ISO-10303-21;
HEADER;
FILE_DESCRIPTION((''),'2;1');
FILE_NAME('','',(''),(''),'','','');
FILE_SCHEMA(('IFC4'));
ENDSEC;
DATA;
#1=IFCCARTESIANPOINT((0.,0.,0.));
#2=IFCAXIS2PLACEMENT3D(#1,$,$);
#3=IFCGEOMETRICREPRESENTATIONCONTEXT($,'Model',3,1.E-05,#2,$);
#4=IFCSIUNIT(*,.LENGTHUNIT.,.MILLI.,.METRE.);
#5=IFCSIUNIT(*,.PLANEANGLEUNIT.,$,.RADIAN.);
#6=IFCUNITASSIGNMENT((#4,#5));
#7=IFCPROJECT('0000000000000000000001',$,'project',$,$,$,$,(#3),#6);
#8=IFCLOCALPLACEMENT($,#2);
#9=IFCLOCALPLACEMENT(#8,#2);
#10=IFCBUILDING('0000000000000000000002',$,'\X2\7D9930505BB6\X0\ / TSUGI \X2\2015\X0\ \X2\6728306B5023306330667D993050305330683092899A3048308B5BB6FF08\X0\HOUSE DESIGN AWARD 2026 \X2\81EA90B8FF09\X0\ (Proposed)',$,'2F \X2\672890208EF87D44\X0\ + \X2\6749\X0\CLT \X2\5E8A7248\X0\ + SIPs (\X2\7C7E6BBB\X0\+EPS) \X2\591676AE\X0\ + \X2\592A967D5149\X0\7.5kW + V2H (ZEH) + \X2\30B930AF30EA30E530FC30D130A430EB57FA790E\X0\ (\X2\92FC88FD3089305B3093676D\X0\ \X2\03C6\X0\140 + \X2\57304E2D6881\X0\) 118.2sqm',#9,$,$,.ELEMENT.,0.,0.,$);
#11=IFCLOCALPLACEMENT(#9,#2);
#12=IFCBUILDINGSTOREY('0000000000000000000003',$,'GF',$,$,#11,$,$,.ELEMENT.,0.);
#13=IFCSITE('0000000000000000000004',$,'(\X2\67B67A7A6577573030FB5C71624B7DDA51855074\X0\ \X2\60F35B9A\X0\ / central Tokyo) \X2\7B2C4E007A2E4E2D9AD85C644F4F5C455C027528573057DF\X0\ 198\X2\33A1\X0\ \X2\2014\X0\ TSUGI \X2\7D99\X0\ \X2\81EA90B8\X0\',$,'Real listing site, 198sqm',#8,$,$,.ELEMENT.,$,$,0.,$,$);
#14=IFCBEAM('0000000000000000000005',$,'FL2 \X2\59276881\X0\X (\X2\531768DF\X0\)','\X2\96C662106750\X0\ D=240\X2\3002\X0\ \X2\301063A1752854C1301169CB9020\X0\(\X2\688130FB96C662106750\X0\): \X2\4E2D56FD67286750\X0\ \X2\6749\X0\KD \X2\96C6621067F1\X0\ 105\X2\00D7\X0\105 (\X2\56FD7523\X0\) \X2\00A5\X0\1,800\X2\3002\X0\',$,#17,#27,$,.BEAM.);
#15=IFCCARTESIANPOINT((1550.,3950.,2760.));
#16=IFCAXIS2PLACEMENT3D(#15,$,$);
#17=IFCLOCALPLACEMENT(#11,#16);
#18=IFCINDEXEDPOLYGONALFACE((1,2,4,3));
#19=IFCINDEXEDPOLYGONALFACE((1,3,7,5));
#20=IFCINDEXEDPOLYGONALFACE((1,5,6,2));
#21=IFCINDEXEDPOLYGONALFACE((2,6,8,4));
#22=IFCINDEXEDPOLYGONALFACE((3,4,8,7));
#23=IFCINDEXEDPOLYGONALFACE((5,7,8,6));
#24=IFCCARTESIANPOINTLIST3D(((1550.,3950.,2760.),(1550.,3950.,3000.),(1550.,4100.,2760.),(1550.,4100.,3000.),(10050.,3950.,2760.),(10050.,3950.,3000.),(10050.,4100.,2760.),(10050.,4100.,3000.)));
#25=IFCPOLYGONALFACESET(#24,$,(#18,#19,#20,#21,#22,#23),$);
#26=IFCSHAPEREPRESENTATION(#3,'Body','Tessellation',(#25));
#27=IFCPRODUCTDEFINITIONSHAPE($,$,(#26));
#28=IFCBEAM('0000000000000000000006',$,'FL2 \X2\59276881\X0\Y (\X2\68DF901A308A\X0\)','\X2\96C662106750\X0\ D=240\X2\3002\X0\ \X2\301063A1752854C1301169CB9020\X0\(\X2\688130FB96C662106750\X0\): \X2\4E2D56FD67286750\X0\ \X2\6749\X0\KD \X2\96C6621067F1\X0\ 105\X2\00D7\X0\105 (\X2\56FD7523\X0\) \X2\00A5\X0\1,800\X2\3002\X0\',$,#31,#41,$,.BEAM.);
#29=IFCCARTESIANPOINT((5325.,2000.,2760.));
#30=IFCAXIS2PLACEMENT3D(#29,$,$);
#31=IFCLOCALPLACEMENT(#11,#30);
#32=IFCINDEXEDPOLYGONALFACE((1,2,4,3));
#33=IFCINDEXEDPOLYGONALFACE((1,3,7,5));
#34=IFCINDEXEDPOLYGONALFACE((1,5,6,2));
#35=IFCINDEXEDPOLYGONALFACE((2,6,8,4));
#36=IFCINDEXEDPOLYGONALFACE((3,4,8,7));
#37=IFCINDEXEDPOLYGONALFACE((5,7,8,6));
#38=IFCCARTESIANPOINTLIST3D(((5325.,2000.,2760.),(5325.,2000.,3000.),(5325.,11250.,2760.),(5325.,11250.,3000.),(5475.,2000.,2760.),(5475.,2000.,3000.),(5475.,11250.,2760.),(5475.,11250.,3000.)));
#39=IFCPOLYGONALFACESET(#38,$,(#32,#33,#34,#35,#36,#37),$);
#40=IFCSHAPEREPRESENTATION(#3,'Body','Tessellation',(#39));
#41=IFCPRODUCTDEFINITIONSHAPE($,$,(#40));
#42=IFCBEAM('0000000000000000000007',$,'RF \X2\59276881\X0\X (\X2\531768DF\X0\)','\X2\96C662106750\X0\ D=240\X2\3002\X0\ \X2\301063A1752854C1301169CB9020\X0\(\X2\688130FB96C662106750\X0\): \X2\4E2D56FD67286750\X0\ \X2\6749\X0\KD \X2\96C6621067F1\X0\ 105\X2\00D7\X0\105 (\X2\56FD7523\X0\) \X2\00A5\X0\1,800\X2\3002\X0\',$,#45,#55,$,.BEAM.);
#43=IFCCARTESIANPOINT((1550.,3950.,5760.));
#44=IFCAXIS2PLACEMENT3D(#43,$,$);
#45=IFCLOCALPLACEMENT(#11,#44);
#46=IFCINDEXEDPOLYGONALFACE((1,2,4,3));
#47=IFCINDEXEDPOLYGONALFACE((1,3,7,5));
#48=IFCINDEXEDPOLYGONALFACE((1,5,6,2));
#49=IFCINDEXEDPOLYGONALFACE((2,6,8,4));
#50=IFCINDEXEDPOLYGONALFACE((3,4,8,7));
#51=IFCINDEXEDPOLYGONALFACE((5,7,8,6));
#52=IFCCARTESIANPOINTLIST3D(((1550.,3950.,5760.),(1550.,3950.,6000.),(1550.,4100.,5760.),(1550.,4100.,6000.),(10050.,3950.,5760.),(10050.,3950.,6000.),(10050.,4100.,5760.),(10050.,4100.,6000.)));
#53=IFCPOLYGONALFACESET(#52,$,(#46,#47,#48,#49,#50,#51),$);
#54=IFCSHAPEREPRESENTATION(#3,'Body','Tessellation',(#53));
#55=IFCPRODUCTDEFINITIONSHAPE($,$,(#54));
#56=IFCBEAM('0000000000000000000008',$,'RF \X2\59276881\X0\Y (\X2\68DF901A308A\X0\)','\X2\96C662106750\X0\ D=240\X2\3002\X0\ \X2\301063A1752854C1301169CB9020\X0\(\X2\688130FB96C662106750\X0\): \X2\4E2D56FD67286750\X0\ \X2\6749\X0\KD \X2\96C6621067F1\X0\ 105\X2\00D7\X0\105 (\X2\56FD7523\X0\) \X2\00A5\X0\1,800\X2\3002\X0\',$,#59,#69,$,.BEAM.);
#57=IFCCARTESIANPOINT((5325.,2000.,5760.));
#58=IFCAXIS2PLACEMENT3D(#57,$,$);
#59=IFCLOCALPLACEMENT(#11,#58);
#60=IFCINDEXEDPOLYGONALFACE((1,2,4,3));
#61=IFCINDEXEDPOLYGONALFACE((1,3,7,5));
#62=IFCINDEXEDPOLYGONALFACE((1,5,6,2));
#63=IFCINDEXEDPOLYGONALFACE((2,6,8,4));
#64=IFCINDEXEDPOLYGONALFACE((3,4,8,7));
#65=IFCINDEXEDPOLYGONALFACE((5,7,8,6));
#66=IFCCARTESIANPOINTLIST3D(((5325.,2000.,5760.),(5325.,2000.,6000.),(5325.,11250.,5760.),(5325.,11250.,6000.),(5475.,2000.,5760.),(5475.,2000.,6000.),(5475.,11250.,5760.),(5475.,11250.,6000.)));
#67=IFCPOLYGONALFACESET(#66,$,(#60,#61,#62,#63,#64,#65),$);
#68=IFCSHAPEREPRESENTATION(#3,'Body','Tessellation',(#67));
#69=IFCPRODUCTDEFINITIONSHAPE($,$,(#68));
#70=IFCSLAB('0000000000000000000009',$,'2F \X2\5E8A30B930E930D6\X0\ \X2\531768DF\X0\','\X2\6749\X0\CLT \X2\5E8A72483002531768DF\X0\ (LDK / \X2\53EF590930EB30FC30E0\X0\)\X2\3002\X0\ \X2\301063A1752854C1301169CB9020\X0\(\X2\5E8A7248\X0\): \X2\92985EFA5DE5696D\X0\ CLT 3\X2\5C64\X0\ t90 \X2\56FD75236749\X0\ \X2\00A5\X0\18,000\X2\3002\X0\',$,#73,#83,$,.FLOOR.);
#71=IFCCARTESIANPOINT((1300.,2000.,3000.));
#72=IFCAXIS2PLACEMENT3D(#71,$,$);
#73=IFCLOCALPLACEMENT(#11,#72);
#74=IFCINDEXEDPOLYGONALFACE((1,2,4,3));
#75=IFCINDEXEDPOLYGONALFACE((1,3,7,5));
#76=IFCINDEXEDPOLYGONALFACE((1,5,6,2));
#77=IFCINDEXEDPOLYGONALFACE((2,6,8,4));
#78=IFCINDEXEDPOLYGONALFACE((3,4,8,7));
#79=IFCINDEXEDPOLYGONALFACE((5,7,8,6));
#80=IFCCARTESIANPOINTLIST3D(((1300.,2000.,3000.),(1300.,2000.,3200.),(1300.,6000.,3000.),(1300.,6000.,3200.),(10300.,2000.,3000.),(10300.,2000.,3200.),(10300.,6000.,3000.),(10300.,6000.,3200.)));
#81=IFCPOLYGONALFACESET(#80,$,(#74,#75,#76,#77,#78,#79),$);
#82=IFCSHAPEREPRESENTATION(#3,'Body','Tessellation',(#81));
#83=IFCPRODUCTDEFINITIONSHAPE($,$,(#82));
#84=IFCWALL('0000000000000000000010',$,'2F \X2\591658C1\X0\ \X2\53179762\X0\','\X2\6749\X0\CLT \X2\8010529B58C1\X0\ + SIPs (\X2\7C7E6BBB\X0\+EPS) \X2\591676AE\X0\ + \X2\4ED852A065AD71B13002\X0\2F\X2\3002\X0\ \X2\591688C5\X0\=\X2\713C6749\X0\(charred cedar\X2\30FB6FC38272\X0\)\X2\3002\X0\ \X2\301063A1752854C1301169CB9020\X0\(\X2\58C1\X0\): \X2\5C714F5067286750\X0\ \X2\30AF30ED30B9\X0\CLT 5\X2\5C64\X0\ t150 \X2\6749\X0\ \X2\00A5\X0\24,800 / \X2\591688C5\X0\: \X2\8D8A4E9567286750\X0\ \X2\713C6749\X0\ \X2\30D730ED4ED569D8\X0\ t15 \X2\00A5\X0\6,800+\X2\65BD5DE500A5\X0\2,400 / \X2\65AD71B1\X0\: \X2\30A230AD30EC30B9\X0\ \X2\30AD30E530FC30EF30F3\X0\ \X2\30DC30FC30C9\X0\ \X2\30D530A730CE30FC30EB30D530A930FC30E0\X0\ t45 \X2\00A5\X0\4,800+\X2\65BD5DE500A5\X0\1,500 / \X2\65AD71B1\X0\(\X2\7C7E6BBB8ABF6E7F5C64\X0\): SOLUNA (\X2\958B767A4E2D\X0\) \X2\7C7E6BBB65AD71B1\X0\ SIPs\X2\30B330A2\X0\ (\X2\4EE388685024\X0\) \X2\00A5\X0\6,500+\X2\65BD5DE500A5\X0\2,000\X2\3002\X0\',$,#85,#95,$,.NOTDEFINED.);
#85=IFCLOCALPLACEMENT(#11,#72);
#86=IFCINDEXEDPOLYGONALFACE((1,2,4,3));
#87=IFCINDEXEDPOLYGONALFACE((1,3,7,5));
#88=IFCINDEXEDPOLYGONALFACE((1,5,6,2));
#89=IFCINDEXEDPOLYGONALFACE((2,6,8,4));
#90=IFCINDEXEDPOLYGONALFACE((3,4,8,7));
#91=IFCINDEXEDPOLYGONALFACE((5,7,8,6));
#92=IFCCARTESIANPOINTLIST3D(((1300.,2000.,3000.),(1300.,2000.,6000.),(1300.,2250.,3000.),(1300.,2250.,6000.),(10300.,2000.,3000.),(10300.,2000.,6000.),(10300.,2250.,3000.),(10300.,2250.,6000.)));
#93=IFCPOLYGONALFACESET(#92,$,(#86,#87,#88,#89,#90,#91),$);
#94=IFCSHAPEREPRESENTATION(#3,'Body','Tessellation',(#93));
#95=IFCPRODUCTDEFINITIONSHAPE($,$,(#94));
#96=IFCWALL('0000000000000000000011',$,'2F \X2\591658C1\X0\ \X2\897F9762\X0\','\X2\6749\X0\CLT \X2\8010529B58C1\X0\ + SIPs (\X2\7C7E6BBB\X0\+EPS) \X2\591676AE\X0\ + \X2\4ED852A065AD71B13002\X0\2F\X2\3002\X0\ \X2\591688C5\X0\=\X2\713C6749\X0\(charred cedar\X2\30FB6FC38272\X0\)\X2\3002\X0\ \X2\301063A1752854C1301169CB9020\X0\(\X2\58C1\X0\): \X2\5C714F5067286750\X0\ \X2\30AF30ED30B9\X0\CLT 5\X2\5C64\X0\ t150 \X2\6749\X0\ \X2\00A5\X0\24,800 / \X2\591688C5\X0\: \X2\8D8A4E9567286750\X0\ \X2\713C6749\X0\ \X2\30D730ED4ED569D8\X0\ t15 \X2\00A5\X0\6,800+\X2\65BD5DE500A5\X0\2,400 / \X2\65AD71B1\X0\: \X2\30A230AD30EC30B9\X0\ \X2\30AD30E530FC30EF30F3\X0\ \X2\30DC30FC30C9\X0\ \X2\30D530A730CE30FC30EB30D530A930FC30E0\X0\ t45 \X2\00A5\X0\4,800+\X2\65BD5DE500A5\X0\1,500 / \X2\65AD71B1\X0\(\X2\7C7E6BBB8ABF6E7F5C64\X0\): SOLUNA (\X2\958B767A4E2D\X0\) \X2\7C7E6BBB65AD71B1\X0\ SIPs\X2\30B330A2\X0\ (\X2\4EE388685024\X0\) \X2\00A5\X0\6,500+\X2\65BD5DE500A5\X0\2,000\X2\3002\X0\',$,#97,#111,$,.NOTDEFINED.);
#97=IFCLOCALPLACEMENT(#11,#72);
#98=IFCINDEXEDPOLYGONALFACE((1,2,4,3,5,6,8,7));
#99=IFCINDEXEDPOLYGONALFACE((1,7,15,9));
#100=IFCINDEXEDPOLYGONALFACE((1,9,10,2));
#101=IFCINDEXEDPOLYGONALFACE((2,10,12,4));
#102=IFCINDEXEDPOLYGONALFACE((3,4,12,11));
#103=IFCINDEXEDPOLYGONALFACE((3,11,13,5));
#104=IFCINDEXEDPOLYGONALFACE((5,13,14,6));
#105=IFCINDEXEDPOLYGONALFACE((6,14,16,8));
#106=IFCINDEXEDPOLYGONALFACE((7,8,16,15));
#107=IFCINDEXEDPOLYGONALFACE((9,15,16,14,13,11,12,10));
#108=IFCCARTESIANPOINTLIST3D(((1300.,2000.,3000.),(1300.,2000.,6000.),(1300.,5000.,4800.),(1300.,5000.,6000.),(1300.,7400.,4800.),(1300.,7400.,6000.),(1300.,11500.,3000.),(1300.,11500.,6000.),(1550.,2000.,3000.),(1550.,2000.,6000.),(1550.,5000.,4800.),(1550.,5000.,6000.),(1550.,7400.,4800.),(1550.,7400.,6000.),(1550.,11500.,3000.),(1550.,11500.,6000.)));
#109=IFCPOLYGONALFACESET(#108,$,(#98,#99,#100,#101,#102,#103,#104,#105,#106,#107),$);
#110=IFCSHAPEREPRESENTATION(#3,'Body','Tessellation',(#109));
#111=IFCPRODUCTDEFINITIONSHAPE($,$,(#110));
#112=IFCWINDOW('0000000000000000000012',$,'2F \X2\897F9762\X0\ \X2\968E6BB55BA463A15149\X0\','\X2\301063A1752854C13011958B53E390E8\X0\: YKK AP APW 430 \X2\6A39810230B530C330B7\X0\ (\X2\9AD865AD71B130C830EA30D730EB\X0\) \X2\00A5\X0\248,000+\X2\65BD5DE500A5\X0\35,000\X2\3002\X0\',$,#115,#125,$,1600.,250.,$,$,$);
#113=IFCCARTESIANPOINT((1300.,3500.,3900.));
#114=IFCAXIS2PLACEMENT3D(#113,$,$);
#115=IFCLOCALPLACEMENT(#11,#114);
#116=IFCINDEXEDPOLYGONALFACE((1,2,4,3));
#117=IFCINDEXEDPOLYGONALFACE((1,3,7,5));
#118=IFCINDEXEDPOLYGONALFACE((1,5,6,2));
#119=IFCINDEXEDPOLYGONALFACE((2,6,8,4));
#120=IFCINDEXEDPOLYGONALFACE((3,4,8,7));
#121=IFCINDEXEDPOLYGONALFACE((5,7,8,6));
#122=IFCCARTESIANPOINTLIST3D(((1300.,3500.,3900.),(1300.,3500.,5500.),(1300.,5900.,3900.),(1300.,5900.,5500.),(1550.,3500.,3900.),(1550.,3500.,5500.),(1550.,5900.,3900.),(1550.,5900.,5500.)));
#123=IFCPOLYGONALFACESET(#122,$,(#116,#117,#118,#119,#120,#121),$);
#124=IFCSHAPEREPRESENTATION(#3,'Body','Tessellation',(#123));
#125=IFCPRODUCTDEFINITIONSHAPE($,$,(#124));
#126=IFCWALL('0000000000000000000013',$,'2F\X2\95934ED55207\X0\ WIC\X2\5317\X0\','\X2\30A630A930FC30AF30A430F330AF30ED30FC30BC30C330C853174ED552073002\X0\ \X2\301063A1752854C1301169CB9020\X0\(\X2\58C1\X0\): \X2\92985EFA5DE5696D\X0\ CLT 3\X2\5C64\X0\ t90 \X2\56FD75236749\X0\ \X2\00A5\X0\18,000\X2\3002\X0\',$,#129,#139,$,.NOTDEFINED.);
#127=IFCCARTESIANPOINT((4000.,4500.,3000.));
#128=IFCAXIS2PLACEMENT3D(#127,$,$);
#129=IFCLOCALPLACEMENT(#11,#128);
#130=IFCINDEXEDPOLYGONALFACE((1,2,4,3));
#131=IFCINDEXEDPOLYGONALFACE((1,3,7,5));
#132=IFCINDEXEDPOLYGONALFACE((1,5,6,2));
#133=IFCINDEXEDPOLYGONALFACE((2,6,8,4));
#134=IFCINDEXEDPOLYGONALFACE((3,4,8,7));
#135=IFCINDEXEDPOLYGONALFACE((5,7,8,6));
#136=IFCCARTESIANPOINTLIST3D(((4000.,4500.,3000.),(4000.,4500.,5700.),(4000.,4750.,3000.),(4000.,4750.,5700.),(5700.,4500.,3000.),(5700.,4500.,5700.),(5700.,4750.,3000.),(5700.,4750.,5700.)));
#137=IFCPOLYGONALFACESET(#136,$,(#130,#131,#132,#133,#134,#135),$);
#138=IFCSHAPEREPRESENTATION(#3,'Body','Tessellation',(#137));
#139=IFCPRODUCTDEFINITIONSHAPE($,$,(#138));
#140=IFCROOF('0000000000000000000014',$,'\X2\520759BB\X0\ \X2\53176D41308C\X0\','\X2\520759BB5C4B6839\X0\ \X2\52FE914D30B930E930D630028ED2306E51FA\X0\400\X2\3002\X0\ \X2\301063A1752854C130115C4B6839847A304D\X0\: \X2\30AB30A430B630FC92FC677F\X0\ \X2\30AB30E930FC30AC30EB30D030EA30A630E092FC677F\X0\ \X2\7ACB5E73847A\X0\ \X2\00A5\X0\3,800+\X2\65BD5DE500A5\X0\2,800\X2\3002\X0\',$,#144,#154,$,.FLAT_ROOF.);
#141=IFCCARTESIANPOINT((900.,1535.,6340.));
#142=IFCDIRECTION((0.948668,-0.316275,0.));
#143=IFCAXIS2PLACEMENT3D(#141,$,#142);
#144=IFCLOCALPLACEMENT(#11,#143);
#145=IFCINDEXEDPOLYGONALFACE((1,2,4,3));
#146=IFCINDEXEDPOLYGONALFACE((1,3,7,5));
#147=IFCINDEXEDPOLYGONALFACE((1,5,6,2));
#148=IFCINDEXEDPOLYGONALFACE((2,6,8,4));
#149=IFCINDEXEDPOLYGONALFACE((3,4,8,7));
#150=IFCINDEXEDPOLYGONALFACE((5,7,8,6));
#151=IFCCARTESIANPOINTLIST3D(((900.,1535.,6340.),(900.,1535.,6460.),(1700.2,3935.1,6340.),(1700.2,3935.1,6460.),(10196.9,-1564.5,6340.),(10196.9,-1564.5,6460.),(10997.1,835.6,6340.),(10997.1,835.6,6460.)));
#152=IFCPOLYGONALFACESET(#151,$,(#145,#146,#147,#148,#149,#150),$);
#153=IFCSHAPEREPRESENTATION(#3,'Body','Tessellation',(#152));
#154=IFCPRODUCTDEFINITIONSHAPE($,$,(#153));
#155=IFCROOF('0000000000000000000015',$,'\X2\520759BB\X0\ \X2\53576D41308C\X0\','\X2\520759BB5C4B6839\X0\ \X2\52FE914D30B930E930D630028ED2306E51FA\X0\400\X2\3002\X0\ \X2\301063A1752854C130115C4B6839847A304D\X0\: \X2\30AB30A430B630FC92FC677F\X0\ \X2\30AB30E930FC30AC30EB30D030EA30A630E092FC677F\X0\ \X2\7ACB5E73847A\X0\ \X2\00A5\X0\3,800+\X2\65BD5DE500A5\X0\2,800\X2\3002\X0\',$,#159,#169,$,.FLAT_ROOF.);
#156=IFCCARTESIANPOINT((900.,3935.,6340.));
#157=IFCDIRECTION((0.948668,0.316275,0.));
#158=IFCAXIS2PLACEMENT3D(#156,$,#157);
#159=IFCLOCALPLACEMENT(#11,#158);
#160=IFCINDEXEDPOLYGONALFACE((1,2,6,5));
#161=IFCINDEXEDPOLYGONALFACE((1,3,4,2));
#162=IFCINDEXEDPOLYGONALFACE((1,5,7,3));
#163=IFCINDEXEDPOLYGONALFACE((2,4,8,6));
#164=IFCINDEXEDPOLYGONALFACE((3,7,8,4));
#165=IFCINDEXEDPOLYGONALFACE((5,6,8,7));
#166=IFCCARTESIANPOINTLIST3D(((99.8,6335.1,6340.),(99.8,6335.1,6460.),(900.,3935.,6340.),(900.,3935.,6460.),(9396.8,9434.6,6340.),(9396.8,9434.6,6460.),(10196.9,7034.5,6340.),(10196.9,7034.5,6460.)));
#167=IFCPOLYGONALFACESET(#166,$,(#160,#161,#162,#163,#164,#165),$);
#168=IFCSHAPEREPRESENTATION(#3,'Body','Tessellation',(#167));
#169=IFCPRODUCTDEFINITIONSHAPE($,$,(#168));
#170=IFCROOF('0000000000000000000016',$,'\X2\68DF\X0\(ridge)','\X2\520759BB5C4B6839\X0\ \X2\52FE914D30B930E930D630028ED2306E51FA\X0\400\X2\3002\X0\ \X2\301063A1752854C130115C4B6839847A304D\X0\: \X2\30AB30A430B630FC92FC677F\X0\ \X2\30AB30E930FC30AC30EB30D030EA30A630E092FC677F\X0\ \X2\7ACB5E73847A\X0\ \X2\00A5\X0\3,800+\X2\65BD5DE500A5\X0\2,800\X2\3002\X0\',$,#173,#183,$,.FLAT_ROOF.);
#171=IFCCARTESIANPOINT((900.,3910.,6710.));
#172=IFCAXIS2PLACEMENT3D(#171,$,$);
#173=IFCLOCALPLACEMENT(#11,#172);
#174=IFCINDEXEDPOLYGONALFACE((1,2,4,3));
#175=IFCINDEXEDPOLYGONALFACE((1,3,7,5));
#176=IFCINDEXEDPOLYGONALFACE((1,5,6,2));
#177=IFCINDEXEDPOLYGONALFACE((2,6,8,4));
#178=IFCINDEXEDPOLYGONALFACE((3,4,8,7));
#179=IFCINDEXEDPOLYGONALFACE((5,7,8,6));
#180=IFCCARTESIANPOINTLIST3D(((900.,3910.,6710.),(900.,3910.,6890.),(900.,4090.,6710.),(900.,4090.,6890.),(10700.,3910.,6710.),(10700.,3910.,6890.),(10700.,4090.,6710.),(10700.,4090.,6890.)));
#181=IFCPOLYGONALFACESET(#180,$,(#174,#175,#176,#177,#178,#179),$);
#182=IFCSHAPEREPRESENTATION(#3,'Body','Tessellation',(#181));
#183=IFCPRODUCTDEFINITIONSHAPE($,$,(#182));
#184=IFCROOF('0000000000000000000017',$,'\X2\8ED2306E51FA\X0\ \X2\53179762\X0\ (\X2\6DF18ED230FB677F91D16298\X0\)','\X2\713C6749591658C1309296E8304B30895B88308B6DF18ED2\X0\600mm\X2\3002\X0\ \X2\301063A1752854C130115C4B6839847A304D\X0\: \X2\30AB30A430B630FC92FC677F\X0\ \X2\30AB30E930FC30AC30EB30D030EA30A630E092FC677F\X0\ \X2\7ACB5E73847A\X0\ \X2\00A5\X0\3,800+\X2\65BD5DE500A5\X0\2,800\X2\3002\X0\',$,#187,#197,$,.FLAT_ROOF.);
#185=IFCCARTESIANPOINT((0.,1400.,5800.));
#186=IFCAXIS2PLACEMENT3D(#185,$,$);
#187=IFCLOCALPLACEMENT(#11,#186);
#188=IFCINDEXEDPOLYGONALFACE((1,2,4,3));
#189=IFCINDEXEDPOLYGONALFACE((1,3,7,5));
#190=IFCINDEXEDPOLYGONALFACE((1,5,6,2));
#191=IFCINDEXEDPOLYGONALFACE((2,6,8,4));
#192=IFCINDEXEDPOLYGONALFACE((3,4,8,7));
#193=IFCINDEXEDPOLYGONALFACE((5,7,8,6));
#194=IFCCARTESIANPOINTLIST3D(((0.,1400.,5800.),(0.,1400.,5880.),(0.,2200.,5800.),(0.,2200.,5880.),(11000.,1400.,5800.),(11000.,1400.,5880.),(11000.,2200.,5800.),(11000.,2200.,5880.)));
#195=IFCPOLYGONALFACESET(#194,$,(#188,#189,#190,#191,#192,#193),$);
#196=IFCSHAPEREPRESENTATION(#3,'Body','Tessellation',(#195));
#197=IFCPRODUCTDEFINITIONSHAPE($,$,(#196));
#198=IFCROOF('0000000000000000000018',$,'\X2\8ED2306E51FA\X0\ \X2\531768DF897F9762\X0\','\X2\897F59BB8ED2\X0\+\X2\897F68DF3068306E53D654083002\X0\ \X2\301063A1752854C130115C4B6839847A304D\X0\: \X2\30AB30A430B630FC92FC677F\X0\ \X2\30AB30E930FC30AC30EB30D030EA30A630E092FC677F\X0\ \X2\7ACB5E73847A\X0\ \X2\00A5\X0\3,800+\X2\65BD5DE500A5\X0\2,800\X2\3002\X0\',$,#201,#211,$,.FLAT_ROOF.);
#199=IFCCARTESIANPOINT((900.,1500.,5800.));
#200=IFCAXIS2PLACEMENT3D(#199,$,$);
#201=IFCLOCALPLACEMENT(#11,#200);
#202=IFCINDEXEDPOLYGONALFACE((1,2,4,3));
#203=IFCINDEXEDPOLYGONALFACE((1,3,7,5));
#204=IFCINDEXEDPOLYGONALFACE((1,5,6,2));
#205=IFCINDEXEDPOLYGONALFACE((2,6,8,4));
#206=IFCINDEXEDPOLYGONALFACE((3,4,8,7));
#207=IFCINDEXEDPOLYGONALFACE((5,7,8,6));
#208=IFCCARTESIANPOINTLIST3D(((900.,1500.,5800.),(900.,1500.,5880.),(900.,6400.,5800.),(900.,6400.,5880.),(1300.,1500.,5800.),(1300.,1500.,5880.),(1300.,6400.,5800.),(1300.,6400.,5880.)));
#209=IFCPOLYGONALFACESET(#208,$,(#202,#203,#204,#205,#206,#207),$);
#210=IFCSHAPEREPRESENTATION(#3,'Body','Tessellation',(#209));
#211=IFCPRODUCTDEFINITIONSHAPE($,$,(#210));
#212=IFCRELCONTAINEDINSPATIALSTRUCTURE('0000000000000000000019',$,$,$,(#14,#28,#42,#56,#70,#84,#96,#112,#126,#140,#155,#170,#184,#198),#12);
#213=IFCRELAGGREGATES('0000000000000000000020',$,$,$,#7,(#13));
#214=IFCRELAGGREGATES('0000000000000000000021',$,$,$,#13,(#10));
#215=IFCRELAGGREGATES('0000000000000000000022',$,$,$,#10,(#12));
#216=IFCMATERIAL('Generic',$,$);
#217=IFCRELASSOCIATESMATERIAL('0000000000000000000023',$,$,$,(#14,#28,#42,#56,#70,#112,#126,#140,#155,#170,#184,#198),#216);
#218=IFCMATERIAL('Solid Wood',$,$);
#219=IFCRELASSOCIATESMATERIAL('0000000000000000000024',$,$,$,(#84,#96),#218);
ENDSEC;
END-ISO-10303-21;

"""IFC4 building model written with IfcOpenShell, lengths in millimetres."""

from ifc_helpers import new_model, si_unit, frame, frame_2d, origin, place, context, project, spatial, rectangle, extrude, material, element, fill, save


model = new_model("IFC4")

# Units and contexts
model_context = context("Model", 3, precision=1e-05, world=origin())
ifc_project = project(units=[si_unit("LENGTHUNIT", "METRE", prefix="MILLI"), si_unit("PLANEANGLEUNIT", "RADIAN")], contexts=[model_context])

# Site, building, storey
site_placement = place(None, origin())
site = spatial("IfcSite", under=ifc_project, at=site_placement, Name="(架空敷地・山手線内側 想定 / central Tokyo) 第一種中高層住居専用地域 198㎡ — TSUGI 継 自邸", ObjectType="Real listing site, 198sqm", CompositionType="ELEMENT", RefElevation=0.0)
building_placement = place(site_placement, origin())
building = spatial("IfcBuilding", under=site, at=building_placement, Name="継ぐ家 / TSUGI ― 木に倣って継ぐことを覚える家（HOUSE DESIGN AWARD 2026 自邸） (Proposed)", ObjectType="2F 木造軸組 + 杉CLT 床版 + SIPs (籾殻+EPS) 外皮 + 太陽光7.5kW + V2H (ZEH) + スクリューパイル基礎 (鋼製らせん杭 φ140 + 地中梁) 118.2sqm", CompositionType="ELEMENT", ElevationOfRefHeight=0.0, ElevationOfTerrain=0.0)
storey_placement = place(building_placement, origin())
storey = spatial("IfcBuildingStorey", under=building, at=storey_placement, Name="GF", CompositionType="ELEMENT", Elevation=0.0)

# Shared definitions
ifc_material_1 = material(Name="Generic")

# Beams
beam_1_placement = place(storey_placement, frame((1550.0, 3950.0, 2760.0)))
element("IfcBeam", 1, at=beam_1_placement, inside=storey, material=ifc_material_1, Name="FL2 大梁X (北棟)", Description="集成材 D=240。 【採用品】構造(梁・集成材): 中国木材 杉KD 集成柱 105×105 (国産) ¥1,800。", PredefinedType="BEAM", context=model_context, shape_type="SweptSolid", body=[
    extrude(rectangle(XDim=8500.0, YDim=150.0, at=frame_2d((4250.0, 75.0))), frame((1550.0, 3950.0, 2760.0)), (0.0, 0.0, 1.0), 240.0),
])
beam_2_placement = place(storey_placement, frame((5325.0, 2000.0, 2760.0)))
element("IfcBeam", 2, at=beam_2_placement, inside=storey, material=ifc_material_1, Name="FL2 大梁Y (棟通り)", Description="集成材 D=240。 【採用品】構造(梁・集成材): 中国木材 杉KD 集成柱 105×105 (国産) ¥1,800。", PredefinedType="BEAM", context=model_context, shape_type="SweptSolid", body=[
    extrude(rectangle(XDim=150.0, YDim=9250.0, at=frame_2d((75.0, 4625.0))), frame((5325.0, 2000.0, 2760.0)), (0.0, 0.0, 1.0), 240.0),
])
beam_3_placement = place(storey_placement, frame((1550.0, 3950.0, 5760.0)))
element("IfcBeam", 3, at=beam_3_placement, inside=storey, material=ifc_material_1, Name="RF 大梁X (北棟)", Description="集成材 D=240。 【採用品】構造(梁・集成材): 中国木材 杉KD 集成柱 105×105 (国産) ¥1,800。", PredefinedType="BEAM", context=model_context, shape_type="SweptSolid", body=[
    extrude(rectangle(XDim=8500.0, YDim=150.0, at=frame_2d((4250.0, 75.0))), frame((1550.0, 3950.0, 5760.0)), (0.0, 0.0, 1.0), 240.0),
])
beam_4_placement = place(storey_placement, frame((5325.0, 2000.0, 5760.0)))
element("IfcBeam", 4, at=beam_4_placement, inside=storey, material=ifc_material_1, Name="RF 大梁Y (棟通り)", Description="集成材 D=240。 【採用品】構造(梁・集成材): 中国木材 杉KD 集成柱 105×105 (国産) ¥1,800。", PredefinedType="BEAM", context=model_context, shape_type="SweptSolid", body=[
    extrude(rectangle(XDim=150.0, YDim=9250.0, at=frame_2d((75.0, 4625.0))), frame((5325.0, 2000.0, 5760.0)), (0.0, 0.0, 1.0), 240.0),
])

# Slab
slab_placement = place(storey_placement, frame((1300.0, 2000.0, 3000.0)))
element("IfcSlab", 5, at=slab_placement, inside=storey, material=ifc_material_1, Name="2F 床スラブ 北棟", Description="杉CLT 床版。北棟 (LDK / 可変ルーム)。 【採用品】構造(床版): 銘建工業 CLT 3層 t90 国産杉 ¥18,000。", PredefinedType="FLOOR", context=model_context, shape_type="SweptSolid", body=[
    extrude(rectangle(XDim=9000.0, YDim=4000.0, at=frame_2d((4500.0, 2000.0))), frame((1300.0, 2000.0, 3000.0)), (0.0, 0.0, 1.0), 200.0),
])

# Wall
ifc_material_2 = material(Name="Solid Wood")
wall_1_placement = place(storey_placement, frame((1300.0, 2000.0, 3000.0)))
element("IfcWall", 6, at=wall_1_placement, inside=storey, material=ifc_material_2, Name="2F 外壁 北面", Description="杉CLT 耐力壁 + SIPs (籾殻+EPS) 外皮 + 付加断熱。2F。 外装=焼杉(charred cedar・濃色)。 【採用品】構造(壁): 山佐木材 クロスCLT 5層 t150 杉 ¥24,800 / 外装: 越井木材 焼杉 プロ仕様 t15 ¥6,800+施工¥2,400 / 断熱: アキレス キューワン ボード フェノールフォーム t45 ¥4,800+施工¥1,500 / 断熱(籾殻調湿層): SOLUNA (開発中) 籾殻断熱 SIPsコア (代表値) ¥6,500+施工¥2,000。", PredefinedType="NOTDEFINED", context=model_context, shape_type="SweptSolid", body=[
    extrude(rectangle(XDim=9000.0, YDim=250.0, at=frame_2d((4500.0, 125.0))), frame((1300.0, 2000.0, 3000.0)), (0.0, 0.0, 1.0), 3000.0),
])

# Wall, opening, window
wall_2_placement = place(storey_placement, frame((1300.0, 2000.0, 3000.0)))
wall_2 = element("IfcWall", 7, at=wall_2_placement, inside=storey, material=ifc_material_2, Name="2F 外壁 西面", Description="杉CLT 耐力壁 + SIPs (籾殻+EPS) 外皮 + 付加断熱。2F。 外装=焼杉(charred cedar・濃色)。 【採用品】構造(壁): 山佐木材 クロスCLT 5層 t150 杉 ¥24,800 / 外装: 越井木材 焼杉 プロ仕様 t15 ¥6,800+施工¥2,400 / 断熱: アキレス キューワン ボード フェノールフォーム t45 ¥4,800+施工¥1,500 / 断熱(籾殻調湿層): SOLUNA (開発中) 籾殻断熱 SIPsコア (代表値) ¥6,500+施工¥2,000。", PredefinedType="NOTDEFINED", context=model_context, shape_type="SweptSolid", body=[
    extrude(rectangle(XDim=250.0, YDim=9500.0, at=frame_2d((125.0, 4750.0))), frame((1300.0, 2000.0, 3000.0)), (0.0, 0.0, 1.0), 3000.0),
])
opening_placement = place(storey_placement, frame((1300.0, 3500.0, 3900.0)))
opening = element("IfcOpeningElement", 8, at=opening_placement, cuts=wall_2, PredefinedType="NOTDEFINED", context=model_context, shape_type="SweptSolid", body=[
    extrude(rectangle(XDim=250.0, YDim=2400.0, at=frame_2d((125.0, 1200.0))), frame((1300.0, 3500.0, 3900.0)), (0.0, 0.0, 1.0), 1600.0),
])
window_placement = place(storey_placement, frame((1300.0, 3500.0, 3900.0)))
window = element("IfcWindow", 9, at=window_placement, inside=storey, material=ifc_material_1, Name="2F 西面 階段室採光", Description="【採用品】開口部: YKK AP APW 430 樹脂サッシ (高断熱トリプル) ¥248,000+施工¥35,000。", OverallHeight=1600.0, OverallWidth=250.0, context=model_context, shape_type="SweptSolid", body=[
    extrude(rectangle(XDim=250.0, YDim=2400.0, at=frame_2d((125.0, 1200.0))), frame((1300.0, 3500.0, 3900.0)), (0.0, 0.0, 1.0), 1600.0),
])
fill(opening, window)

# Wall
wall_3_placement = place(storey_placement, frame((4000.0, 4500.0, 3000.0)))
element("IfcWall", 10, at=wall_3_placement, inside=storey, material=ifc_material_1, Name="2F間仕切 WIC北", Description="ウォークインクローゼット北仕切。 【採用品】構造(壁): 銘建工業 CLT 3層 t90 国産杉 ¥18,000。", PredefinedType="NOTDEFINED", context=model_context, shape_type="SweptSolid", body=[
    extrude(rectangle(XDim=1700.0, YDim=250.0, at=frame_2d((850.0, 125.0))), frame((4000.0, 4500.0, 3000.0)), (0.0, 0.0, 1.0), 2700.0),
])

# Roofs
roof_1_placement = place(storey_placement, frame((900.0, 1535.0, 6340.0), x_axis=(0.948668, -0.316275, 0.0)))
element("IfcRoof", 11, at=roof_1_placement, inside=storey, material=ifc_material_1, Name="切妻 北流れ", Description="切妻屋根 勾配スラブ。軒の出400。 【採用品】屋根葺き: カイザー鋼板 カラーガルバリウム鋼板 立平葺 ¥3,800+施工¥2,800。", PredefinedType="FLAT_ROOF", context=model_context, shape_type="SweptSolid", body=[
    extrude(rectangle(XDim=9800.0, YDim=2530.0, at=frame_2d((4900.0, 1265.0))), frame((900.0, 1535.0, 6340.0), x_axis=(0.948668, -0.316275, 0.0)), (0.0, 0.0, 1.0), 120.0),
])
roof_2_placement = place(storey_placement, frame((900.0, 3935.0, 6340.0), x_axis=(0.948668, 0.316275, 0.0)))
element("IfcRoof", 12, at=roof_2_placement, inside=storey, material=ifc_material_1, Name="切妻 南流れ", Description="切妻屋根 勾配スラブ。軒の出400。 【採用品】屋根葺き: カイザー鋼板 カラーガルバリウム鋼板 立平葺 ¥3,800+施工¥2,800。", PredefinedType="FLAT_ROOF", context=model_context, shape_type="SweptSolid", body=[
    extrude(rectangle(XDim=9800.0, YDim=2530.0, at=frame_2d((4900.0, 1265.0))), frame((900.0, 3935.0, 6340.0), x_axis=(0.948668, 0.316275, 0.0)), (0.0, 0.0, 1.0), 120.0),
])
roof_3_placement = place(storey_placement, frame((900.0, 3910.0, 6710.0)))
element("IfcRoof", 13, at=roof_3_placement, inside=storey, material=ifc_material_1, Name="棟(ridge)", Description="切妻屋根 勾配スラブ。軒の出400。 【採用品】屋根葺き: カイザー鋼板 カラーガルバリウム鋼板 立平葺 ¥3,800+施工¥2,800。", PredefinedType="FLAT_ROOF", context=model_context, shape_type="SweptSolid", body=[
    extrude(rectangle(XDim=9800.0, YDim=180.0, at=frame_2d((4900.0, 90.0))), frame((900.0, 3910.0, 6710.0)), (0.0, 0.0, 1.0), 180.0),
])
roof_4_placement = place(storey_placement, frame((0.0, 1400.0, 5800.0)))
element("IfcRoof", 14, at=roof_4_placement, inside=storey, material=ifc_material_1, Name="軒の出 北面 (深軒・板金折)", Description="焼杉外壁を雨から守る深軒600mm。 【採用品】屋根葺き: カイザー鋼板 カラーガルバリウム鋼板 立平葺 ¥3,800+施工¥2,800。", PredefinedType="FLAT_ROOF", context=model_context, shape_type="SweptSolid", body=[
    extrude(rectangle(XDim=11000.0, YDim=800.0, at=frame_2d((5500.0, 400.0))), frame((0.0, 1400.0, 5800.0)), (0.0, 0.0, 1.0), 80.0),
])
roof_5_placement = place(storey_placement, frame((900.0, 1500.0, 5800.0)))
element("IfcRoof", 15, at=roof_5_placement, inside=storey, material=ifc_material_1, Name="軒の出 北棟西面", Description="西妻軒+西棟との取合。 【採用品】屋根葺き: カイザー鋼板 カラーガルバリウム鋼板 立平葺 ¥3,800+施工¥2,800。", PredefinedType="FLAT_ROOF", context=model_context, shape_type="SweptSolid", body=[
    extrude(rectangle(XDim=400.0, YDim=4900.0, at=frame_2d((200.0, 2450.0))), frame((900.0, 1500.0, 5800.0)), (0.0, 0.0, 1.0), 80.0),
])

save(model, "model.ifc")
